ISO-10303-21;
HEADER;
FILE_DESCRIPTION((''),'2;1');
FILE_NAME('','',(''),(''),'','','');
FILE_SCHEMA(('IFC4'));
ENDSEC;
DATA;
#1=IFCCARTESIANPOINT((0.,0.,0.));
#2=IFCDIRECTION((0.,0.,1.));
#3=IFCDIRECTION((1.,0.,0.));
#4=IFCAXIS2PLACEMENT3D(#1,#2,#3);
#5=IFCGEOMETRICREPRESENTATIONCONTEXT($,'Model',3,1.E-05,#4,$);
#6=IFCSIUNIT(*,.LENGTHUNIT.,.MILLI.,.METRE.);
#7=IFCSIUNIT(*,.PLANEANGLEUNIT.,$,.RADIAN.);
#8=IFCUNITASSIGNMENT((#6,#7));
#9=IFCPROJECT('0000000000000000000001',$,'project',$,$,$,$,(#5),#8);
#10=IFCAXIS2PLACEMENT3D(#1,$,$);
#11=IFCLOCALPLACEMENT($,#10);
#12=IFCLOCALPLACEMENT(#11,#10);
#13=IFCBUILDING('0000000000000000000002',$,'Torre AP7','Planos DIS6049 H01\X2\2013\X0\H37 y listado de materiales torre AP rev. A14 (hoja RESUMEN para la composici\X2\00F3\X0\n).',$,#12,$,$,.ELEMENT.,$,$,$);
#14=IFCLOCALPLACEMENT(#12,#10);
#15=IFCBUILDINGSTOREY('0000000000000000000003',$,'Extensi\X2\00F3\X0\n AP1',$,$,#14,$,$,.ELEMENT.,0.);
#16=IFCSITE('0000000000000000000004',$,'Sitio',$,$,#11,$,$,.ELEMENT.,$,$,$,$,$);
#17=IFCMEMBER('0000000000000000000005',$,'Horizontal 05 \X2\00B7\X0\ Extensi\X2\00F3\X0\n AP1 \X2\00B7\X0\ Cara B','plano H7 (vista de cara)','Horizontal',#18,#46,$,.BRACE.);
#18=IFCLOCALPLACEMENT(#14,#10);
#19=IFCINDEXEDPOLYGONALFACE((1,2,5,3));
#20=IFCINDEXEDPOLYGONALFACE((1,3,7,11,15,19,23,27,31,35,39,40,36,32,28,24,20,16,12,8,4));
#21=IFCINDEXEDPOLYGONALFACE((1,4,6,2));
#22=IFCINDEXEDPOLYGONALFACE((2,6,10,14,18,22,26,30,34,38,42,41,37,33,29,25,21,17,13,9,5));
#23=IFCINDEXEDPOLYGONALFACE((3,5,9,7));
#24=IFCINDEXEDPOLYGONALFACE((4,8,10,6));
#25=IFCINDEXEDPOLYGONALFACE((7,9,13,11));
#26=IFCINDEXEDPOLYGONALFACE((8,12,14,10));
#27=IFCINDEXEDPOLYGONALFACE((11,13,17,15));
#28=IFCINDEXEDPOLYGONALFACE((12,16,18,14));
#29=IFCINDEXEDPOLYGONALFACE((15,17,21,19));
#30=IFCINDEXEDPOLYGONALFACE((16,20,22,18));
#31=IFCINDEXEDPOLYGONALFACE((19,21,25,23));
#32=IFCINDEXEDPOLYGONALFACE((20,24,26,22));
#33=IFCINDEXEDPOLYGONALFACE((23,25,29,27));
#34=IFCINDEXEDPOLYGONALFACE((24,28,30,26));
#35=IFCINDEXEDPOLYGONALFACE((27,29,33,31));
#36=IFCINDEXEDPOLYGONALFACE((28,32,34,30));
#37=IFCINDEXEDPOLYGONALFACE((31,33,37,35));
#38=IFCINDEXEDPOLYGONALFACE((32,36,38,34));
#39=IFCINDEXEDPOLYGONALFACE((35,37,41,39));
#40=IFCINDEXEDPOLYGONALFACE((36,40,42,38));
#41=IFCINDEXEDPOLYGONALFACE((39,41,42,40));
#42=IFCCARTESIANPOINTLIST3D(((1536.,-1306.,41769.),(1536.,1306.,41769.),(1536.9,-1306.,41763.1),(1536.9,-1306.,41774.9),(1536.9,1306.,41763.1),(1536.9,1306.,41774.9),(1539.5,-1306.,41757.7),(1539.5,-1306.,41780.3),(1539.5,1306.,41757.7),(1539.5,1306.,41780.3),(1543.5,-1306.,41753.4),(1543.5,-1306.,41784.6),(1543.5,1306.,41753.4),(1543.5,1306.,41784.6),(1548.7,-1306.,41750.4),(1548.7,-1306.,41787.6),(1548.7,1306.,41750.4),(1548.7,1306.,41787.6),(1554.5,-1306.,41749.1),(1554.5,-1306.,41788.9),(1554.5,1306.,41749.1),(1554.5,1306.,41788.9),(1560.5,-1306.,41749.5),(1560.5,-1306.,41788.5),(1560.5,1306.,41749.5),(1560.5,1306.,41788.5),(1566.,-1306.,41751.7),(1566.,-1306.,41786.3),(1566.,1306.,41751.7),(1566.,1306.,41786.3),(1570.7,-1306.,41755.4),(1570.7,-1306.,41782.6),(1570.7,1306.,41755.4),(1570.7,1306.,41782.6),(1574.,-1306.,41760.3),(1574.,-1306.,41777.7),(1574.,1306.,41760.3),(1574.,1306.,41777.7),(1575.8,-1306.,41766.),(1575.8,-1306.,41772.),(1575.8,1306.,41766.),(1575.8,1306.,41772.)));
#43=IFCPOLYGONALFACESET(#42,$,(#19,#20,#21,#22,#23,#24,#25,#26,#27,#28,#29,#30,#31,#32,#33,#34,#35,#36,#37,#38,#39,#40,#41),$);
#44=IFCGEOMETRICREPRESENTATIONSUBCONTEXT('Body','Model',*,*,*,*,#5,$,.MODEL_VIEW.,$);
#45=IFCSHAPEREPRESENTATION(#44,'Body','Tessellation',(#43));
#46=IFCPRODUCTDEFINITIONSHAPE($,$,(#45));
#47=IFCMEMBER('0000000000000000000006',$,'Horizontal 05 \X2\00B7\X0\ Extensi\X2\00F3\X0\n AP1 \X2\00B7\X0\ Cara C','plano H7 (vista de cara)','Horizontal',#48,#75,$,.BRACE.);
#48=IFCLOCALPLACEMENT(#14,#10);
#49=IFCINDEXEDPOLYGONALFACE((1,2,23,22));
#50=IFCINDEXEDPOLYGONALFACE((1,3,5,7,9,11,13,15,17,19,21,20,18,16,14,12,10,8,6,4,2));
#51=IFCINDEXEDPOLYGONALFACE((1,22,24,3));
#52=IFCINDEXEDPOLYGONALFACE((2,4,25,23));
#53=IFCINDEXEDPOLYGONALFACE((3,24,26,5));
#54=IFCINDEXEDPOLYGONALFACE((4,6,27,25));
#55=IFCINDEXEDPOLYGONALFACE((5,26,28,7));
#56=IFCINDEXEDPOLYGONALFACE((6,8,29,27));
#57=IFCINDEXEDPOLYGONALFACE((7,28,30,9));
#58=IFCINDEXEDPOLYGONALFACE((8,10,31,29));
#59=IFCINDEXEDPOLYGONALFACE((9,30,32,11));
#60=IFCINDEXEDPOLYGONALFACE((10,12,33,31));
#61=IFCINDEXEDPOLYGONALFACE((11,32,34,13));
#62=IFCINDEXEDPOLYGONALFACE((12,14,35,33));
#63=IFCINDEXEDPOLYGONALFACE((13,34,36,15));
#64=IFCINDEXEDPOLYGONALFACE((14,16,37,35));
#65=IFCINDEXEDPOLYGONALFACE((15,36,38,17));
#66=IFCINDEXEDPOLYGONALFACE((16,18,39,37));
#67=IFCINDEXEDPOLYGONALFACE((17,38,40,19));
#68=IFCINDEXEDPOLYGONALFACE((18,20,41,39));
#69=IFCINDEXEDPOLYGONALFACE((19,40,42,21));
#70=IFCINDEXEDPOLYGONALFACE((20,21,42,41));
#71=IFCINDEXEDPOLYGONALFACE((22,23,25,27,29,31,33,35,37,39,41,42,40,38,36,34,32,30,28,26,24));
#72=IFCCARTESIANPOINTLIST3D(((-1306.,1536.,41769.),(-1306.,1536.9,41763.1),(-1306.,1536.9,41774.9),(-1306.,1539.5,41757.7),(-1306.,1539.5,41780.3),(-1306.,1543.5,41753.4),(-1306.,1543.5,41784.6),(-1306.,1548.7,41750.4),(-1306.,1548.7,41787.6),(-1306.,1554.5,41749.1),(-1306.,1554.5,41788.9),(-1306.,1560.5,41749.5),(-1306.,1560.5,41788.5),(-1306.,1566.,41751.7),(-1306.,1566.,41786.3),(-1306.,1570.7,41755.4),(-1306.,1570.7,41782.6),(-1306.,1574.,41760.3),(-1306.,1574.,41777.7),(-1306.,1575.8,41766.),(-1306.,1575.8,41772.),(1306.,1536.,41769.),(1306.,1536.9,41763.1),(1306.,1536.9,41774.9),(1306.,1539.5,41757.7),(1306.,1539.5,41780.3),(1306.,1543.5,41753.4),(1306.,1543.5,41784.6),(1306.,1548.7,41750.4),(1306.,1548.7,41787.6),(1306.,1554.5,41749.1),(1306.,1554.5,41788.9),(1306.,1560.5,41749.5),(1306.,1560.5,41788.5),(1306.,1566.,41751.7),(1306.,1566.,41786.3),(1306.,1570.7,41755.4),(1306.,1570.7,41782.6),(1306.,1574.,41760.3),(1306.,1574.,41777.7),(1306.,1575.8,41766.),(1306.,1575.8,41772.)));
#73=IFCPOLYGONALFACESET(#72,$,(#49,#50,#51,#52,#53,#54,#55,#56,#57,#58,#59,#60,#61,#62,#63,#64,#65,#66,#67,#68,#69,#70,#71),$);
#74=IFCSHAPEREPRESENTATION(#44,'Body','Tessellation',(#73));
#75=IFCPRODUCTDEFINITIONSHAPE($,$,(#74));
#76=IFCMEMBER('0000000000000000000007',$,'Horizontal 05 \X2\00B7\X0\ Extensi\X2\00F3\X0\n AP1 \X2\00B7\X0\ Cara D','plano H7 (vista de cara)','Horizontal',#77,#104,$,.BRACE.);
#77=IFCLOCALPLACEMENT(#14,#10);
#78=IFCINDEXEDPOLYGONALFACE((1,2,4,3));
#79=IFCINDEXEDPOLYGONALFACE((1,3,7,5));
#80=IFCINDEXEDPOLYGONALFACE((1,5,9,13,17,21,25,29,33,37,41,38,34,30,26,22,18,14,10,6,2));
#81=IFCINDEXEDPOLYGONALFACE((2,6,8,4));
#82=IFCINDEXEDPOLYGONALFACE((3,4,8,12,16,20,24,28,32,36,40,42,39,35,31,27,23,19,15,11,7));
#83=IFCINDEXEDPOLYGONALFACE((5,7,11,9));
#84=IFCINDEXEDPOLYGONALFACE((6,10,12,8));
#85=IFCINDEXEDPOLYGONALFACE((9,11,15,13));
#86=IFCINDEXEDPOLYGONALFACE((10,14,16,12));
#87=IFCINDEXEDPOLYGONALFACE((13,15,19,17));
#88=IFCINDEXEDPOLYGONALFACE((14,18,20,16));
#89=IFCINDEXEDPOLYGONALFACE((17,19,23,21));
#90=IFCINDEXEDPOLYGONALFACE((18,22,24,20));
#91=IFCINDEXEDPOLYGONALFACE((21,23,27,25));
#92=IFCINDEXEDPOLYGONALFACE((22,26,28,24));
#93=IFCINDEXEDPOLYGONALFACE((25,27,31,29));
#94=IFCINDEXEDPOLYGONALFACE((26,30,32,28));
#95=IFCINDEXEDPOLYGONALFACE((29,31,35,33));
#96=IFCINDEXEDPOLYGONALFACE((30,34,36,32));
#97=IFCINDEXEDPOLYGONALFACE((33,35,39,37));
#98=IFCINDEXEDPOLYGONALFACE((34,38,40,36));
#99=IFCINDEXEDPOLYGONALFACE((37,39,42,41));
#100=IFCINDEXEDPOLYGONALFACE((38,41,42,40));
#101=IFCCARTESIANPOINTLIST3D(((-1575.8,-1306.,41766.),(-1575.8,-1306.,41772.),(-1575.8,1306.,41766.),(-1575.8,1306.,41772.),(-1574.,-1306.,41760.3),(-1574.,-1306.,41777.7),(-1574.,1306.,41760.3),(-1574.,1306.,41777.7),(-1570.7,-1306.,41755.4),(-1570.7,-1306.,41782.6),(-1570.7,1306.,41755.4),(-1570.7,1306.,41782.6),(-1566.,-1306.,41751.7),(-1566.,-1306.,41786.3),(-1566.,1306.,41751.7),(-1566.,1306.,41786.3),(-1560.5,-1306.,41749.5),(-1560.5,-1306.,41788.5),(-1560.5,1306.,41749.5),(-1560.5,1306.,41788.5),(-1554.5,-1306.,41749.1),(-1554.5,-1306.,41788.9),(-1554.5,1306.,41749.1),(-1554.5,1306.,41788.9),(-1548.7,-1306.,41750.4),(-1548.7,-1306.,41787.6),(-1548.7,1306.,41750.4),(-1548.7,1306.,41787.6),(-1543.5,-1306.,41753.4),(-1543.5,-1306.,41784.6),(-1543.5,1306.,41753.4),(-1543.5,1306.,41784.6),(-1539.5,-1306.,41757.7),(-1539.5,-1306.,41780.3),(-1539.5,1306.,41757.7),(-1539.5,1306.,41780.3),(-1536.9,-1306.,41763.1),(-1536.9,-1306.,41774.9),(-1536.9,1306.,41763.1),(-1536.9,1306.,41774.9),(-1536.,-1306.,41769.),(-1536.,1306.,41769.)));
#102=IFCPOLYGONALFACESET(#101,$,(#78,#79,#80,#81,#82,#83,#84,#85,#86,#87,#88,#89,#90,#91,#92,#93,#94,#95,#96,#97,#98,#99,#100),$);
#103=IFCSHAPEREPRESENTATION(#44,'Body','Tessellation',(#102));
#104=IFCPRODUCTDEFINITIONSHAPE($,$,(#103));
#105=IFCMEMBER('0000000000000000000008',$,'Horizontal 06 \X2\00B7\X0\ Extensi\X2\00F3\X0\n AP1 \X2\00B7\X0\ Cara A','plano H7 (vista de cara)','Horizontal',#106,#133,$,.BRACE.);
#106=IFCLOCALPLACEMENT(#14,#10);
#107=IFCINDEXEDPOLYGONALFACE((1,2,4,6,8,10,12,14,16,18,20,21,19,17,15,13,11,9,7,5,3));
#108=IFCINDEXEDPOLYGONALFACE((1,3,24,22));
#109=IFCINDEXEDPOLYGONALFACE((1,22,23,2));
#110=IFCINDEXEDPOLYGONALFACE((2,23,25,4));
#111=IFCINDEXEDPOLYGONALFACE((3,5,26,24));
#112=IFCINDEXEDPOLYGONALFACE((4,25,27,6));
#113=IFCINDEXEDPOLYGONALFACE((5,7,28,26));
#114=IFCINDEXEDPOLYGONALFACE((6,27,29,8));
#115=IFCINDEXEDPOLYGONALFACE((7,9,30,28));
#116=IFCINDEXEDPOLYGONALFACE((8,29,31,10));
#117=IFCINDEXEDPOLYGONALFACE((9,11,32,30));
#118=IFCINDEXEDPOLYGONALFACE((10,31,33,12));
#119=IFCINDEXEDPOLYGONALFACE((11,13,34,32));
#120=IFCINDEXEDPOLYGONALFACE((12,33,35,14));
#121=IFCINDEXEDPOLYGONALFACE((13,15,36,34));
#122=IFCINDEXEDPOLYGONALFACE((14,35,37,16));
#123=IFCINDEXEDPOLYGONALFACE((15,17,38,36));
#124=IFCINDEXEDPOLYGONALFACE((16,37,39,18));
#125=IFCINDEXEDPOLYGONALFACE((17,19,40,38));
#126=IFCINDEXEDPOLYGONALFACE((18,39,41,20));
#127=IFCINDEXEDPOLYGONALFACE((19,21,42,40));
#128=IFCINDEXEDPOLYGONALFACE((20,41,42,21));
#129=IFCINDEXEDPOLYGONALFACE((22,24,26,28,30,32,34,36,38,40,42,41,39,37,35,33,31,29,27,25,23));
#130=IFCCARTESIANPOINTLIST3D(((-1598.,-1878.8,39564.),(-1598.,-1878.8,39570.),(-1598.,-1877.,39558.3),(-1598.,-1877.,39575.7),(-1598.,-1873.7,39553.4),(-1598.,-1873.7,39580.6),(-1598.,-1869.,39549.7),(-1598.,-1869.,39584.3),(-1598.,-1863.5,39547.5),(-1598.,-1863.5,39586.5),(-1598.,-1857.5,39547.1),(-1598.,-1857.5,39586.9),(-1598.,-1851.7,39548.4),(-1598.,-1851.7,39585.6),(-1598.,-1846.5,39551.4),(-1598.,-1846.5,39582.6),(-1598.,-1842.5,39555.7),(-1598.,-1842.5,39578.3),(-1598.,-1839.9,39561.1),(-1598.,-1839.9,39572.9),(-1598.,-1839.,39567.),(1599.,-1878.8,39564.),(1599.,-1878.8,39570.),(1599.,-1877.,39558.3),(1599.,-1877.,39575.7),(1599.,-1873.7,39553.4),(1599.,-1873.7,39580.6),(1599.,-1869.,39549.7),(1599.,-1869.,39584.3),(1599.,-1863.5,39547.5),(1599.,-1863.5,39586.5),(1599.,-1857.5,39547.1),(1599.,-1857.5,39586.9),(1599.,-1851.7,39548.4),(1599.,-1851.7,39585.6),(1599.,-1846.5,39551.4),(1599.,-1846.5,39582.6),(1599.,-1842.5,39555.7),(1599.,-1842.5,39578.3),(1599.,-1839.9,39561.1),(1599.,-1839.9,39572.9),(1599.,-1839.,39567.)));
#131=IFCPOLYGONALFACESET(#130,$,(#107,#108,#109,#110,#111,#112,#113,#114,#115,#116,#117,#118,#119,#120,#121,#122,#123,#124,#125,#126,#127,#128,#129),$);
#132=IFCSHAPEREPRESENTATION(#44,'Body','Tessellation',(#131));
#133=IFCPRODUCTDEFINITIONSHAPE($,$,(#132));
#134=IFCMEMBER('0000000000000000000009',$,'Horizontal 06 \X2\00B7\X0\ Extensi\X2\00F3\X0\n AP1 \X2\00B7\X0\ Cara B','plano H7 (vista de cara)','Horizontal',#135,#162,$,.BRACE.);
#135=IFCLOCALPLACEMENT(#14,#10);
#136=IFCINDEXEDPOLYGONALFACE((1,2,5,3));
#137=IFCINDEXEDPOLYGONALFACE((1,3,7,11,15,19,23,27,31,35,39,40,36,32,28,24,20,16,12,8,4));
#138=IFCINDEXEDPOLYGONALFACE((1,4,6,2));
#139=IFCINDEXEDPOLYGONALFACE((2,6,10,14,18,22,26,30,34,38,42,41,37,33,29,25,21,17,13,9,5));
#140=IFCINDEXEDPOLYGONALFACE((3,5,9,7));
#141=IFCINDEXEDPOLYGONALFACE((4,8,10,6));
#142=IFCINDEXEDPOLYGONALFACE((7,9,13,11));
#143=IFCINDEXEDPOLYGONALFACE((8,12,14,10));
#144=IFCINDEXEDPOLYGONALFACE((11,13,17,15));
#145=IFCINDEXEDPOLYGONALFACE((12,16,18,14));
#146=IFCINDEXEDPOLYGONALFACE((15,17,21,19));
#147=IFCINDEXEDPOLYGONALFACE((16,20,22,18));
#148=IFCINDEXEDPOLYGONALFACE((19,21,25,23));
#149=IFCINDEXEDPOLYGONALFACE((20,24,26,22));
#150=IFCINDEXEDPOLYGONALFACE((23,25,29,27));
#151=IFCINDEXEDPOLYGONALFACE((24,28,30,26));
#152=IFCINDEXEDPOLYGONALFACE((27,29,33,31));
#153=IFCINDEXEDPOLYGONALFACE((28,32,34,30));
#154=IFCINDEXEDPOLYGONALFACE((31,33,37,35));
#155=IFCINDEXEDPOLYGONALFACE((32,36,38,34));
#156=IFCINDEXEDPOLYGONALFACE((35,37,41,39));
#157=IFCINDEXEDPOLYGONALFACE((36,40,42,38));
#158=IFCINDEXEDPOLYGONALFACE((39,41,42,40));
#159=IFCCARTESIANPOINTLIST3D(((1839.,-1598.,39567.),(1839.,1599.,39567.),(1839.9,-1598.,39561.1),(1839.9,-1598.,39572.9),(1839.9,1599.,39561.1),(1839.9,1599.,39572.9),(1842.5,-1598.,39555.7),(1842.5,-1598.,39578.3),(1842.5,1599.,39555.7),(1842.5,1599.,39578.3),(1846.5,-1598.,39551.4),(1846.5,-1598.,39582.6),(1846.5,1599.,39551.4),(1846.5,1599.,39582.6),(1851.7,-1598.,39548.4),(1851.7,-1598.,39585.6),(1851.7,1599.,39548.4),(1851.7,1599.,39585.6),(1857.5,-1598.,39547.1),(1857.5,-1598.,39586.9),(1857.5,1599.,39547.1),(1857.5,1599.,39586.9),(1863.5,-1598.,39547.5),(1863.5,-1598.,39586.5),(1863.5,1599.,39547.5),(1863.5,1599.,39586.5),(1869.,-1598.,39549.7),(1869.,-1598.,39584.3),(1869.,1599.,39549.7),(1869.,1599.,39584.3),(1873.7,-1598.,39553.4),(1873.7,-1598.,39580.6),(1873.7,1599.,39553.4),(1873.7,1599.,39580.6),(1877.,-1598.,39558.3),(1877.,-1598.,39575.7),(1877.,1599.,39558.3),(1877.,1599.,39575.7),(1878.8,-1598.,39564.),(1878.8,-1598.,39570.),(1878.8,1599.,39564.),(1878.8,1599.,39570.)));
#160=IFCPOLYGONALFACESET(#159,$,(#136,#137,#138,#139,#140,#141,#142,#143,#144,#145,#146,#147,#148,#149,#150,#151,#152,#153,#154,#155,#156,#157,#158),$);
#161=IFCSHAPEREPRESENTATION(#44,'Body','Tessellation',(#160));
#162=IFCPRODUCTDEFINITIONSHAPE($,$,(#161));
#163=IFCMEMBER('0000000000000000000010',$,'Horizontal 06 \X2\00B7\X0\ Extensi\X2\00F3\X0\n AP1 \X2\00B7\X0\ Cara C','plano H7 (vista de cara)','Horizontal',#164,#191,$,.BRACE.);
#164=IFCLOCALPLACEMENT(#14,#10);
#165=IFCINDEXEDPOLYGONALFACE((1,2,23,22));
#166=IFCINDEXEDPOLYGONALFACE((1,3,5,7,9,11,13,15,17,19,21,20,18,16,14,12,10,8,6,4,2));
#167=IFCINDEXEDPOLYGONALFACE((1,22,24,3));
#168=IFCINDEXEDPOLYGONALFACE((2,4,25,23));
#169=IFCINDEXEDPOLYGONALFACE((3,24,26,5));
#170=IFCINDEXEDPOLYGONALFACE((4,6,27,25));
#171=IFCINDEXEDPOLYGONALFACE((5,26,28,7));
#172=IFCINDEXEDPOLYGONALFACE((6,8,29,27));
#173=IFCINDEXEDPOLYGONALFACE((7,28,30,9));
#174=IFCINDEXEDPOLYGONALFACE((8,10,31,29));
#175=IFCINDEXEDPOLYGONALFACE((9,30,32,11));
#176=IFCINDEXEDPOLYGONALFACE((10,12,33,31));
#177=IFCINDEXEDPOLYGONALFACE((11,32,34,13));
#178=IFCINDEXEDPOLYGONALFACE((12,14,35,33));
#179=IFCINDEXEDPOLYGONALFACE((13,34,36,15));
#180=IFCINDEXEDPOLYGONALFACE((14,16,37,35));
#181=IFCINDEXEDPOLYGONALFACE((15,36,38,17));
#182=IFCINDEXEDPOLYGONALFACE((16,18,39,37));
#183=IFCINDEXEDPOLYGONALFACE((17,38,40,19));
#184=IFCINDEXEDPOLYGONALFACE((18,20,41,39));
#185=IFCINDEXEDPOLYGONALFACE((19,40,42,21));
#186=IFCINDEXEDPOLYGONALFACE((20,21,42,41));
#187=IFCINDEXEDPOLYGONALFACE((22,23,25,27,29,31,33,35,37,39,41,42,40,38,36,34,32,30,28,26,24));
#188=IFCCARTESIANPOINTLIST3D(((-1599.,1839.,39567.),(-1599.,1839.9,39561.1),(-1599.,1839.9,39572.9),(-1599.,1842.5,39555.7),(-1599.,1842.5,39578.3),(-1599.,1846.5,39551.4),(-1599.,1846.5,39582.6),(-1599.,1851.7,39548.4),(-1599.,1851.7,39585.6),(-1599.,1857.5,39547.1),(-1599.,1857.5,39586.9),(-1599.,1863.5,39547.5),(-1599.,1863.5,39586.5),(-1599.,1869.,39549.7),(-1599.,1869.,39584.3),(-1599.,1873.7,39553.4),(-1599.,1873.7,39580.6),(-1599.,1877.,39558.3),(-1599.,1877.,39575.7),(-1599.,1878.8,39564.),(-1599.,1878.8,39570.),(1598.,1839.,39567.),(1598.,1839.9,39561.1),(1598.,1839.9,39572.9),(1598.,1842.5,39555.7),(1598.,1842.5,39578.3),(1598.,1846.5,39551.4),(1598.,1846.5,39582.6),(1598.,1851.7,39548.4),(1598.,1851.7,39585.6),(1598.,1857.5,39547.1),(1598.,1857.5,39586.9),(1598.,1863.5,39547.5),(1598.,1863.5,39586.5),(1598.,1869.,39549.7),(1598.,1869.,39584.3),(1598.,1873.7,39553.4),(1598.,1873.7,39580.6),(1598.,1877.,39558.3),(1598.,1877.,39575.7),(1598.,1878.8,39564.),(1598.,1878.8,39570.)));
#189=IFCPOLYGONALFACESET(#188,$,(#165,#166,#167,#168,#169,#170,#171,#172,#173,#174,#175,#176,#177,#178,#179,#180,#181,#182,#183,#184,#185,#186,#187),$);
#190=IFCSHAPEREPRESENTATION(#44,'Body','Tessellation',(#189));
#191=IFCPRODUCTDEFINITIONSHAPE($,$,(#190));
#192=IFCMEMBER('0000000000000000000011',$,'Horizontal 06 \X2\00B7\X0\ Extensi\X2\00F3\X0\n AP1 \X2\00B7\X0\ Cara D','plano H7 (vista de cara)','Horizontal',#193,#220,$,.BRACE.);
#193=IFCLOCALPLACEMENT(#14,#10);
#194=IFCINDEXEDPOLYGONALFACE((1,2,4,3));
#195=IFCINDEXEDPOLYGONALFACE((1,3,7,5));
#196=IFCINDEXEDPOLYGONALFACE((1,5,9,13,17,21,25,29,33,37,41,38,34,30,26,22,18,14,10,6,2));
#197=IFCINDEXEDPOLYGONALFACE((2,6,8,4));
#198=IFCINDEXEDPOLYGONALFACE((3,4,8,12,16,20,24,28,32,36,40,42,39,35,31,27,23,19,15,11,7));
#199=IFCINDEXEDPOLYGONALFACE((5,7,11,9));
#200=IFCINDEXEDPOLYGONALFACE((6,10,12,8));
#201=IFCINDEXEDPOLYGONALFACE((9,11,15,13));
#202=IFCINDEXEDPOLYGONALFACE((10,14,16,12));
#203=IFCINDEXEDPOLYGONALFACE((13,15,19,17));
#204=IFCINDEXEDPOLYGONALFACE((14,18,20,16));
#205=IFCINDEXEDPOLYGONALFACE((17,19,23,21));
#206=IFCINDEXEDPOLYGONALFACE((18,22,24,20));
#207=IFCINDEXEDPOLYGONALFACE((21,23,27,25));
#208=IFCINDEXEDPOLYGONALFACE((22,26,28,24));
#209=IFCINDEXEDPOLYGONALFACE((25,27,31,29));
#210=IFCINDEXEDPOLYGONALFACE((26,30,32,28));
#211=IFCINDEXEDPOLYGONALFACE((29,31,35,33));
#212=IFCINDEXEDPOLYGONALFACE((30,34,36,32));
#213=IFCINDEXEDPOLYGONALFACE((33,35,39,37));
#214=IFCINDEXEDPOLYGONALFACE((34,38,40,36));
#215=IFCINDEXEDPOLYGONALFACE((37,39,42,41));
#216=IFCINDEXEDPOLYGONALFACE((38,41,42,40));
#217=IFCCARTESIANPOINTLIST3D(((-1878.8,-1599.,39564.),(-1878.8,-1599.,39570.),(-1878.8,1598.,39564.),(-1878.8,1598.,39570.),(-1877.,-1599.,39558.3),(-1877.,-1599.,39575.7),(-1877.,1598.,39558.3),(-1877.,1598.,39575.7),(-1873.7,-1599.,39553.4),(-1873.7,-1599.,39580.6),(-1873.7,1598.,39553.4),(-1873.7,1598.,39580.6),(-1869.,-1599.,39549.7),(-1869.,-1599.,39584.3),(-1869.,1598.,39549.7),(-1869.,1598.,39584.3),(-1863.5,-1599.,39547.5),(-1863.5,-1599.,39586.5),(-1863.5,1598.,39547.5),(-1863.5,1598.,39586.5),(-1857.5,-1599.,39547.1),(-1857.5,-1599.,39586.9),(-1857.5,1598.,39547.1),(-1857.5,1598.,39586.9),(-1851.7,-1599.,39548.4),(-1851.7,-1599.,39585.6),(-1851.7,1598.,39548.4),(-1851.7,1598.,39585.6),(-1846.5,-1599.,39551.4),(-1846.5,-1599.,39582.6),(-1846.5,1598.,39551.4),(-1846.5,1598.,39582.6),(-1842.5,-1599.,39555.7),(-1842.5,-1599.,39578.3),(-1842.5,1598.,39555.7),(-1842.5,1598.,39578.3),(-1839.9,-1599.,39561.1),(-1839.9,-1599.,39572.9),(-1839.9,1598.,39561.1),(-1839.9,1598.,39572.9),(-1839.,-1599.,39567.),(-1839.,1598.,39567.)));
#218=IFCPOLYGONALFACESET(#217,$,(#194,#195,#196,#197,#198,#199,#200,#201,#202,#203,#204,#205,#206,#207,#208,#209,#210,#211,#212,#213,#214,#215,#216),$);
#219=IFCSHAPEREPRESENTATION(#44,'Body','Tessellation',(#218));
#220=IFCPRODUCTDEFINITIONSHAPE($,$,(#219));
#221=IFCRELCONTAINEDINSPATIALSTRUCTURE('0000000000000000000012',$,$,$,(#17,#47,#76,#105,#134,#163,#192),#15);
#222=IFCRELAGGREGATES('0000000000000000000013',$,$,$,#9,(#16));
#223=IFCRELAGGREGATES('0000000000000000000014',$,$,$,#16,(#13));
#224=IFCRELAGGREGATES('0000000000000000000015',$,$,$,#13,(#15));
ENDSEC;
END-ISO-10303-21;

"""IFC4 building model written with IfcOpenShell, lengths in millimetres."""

from ifc_helpers import new_model, si_unit, frame, origin, origin_with_axes, place, context, subcontext, project, spatial, circle, extrude, element, save


model = new_model("IFC4")

# Units and contexts
model_context = context("Model", 3, precision=1e-05, world=origin_with_axes())
body_context = subcontext(model_context, "Body", "Model", "MODEL_VIEW")
ifc_project = project(units=[si_unit("LENGTHUNIT", "METRE", prefix="MILLI"), si_unit("PLANEANGLEUNIT", "RADIAN")], contexts=[model_context])

# Site, building, storey
site_placement = place(None, origin())
site = spatial("IfcSite", under=ifc_project, at=site_placement, Name="Sitio", CompositionType="ELEMENT")
building_placement = place(site_placement, origin())
building = spatial("IfcBuilding", under=site, at=building_placement, Name="Torre AP7", Description="Planos DIS6049 H01–H37 y listado de materiales torre AP rev. A14 (hoja RESUMEN para la composición).", CompositionType="ELEMENT")
storey_placement = place(building_placement, origin())
storey = spatial("IfcBuildingStorey", under=building, at=storey_placement, Name="Extensión AP1", CompositionType="ELEMENT", Elevation=0.0)

# Members
for number, where, z_axis, x_axis, name in (
    (1, (1556.0, 1306.0, 41769.0), (0.0, -1.0, 0.0), (-1.0, 0.0, 0.0), "Horizontal 05 · Extensión AP1 · Cara B"),
    (2, (-1306.0, 1556.0, 41769.0), (1.0, 0.0, 0.0), (0.0, -1.0, 0.0), "Horizontal 05 · Extensión AP1 · Cara C"),
    (3, (-1556.0, -1306.0, 41769.0), (0.0, 1.0, 0.0), (1.0, 0.0, 0.0), "Horizontal 05 · Extensión AP1 · Cara D"),
):
    element("IfcMember", number, at=place(storey_placement, frame(where, z_axis=z_axis, x_axis=x_axis)), inside=storey, Name=name, Description="plano H7 (vista de cara)", ObjectType="Horizontal", PredefinedType="BRACE", context=body_context, shape_type="SweptSolid", body=[
        extrude(circle(Radius=20.0), None, (0.0, 0.0, 1.0), 2612.0),
    ])
for number, where, z_axis, x_axis, name in (
    (4, (1599.0, -1859.0, 39567.0), (-1.0, 0.0, 0.0), (0.0, 1.0, 0.0), "Horizontal 06 · Extensión AP1 · Cara A"),
    (5, (1859.0, 1599.0, 39567.0), (0.0, -1.0, 0.0), (-1.0, 0.0, 0.0), "Horizontal 06 · Extensión AP1 · Cara B"),
    (6, (-1599.0, 1859.0, 39567.0), (1.0, 0.0, 0.0), (0.0, -1.0, 0.0), "Horizontal 06 · Extensión AP1 · Cara C"),
    (7, (-1859.0, -1599.0, 39567.0), (0.0, 1.0, 0.0), (1.0, 0.0, 0.0), "Horizontal 06 · Extensión AP1 · Cara D"),
):
    element("IfcMember", number, at=place(storey_placement, frame(where, z_axis=z_axis, x_axis=x_axis)), inside=storey, Name=name, Description="plano H7 (vista de cara)", ObjectType="Horizontal", PredefinedType="BRACE", context=body_context, shape_type="SweptSolid", body=[
        extrude(circle(Radius=20.0), None, (0.0, 0.0, 1.0), 3197.0),
    ])

save(model, "model.ifc")
